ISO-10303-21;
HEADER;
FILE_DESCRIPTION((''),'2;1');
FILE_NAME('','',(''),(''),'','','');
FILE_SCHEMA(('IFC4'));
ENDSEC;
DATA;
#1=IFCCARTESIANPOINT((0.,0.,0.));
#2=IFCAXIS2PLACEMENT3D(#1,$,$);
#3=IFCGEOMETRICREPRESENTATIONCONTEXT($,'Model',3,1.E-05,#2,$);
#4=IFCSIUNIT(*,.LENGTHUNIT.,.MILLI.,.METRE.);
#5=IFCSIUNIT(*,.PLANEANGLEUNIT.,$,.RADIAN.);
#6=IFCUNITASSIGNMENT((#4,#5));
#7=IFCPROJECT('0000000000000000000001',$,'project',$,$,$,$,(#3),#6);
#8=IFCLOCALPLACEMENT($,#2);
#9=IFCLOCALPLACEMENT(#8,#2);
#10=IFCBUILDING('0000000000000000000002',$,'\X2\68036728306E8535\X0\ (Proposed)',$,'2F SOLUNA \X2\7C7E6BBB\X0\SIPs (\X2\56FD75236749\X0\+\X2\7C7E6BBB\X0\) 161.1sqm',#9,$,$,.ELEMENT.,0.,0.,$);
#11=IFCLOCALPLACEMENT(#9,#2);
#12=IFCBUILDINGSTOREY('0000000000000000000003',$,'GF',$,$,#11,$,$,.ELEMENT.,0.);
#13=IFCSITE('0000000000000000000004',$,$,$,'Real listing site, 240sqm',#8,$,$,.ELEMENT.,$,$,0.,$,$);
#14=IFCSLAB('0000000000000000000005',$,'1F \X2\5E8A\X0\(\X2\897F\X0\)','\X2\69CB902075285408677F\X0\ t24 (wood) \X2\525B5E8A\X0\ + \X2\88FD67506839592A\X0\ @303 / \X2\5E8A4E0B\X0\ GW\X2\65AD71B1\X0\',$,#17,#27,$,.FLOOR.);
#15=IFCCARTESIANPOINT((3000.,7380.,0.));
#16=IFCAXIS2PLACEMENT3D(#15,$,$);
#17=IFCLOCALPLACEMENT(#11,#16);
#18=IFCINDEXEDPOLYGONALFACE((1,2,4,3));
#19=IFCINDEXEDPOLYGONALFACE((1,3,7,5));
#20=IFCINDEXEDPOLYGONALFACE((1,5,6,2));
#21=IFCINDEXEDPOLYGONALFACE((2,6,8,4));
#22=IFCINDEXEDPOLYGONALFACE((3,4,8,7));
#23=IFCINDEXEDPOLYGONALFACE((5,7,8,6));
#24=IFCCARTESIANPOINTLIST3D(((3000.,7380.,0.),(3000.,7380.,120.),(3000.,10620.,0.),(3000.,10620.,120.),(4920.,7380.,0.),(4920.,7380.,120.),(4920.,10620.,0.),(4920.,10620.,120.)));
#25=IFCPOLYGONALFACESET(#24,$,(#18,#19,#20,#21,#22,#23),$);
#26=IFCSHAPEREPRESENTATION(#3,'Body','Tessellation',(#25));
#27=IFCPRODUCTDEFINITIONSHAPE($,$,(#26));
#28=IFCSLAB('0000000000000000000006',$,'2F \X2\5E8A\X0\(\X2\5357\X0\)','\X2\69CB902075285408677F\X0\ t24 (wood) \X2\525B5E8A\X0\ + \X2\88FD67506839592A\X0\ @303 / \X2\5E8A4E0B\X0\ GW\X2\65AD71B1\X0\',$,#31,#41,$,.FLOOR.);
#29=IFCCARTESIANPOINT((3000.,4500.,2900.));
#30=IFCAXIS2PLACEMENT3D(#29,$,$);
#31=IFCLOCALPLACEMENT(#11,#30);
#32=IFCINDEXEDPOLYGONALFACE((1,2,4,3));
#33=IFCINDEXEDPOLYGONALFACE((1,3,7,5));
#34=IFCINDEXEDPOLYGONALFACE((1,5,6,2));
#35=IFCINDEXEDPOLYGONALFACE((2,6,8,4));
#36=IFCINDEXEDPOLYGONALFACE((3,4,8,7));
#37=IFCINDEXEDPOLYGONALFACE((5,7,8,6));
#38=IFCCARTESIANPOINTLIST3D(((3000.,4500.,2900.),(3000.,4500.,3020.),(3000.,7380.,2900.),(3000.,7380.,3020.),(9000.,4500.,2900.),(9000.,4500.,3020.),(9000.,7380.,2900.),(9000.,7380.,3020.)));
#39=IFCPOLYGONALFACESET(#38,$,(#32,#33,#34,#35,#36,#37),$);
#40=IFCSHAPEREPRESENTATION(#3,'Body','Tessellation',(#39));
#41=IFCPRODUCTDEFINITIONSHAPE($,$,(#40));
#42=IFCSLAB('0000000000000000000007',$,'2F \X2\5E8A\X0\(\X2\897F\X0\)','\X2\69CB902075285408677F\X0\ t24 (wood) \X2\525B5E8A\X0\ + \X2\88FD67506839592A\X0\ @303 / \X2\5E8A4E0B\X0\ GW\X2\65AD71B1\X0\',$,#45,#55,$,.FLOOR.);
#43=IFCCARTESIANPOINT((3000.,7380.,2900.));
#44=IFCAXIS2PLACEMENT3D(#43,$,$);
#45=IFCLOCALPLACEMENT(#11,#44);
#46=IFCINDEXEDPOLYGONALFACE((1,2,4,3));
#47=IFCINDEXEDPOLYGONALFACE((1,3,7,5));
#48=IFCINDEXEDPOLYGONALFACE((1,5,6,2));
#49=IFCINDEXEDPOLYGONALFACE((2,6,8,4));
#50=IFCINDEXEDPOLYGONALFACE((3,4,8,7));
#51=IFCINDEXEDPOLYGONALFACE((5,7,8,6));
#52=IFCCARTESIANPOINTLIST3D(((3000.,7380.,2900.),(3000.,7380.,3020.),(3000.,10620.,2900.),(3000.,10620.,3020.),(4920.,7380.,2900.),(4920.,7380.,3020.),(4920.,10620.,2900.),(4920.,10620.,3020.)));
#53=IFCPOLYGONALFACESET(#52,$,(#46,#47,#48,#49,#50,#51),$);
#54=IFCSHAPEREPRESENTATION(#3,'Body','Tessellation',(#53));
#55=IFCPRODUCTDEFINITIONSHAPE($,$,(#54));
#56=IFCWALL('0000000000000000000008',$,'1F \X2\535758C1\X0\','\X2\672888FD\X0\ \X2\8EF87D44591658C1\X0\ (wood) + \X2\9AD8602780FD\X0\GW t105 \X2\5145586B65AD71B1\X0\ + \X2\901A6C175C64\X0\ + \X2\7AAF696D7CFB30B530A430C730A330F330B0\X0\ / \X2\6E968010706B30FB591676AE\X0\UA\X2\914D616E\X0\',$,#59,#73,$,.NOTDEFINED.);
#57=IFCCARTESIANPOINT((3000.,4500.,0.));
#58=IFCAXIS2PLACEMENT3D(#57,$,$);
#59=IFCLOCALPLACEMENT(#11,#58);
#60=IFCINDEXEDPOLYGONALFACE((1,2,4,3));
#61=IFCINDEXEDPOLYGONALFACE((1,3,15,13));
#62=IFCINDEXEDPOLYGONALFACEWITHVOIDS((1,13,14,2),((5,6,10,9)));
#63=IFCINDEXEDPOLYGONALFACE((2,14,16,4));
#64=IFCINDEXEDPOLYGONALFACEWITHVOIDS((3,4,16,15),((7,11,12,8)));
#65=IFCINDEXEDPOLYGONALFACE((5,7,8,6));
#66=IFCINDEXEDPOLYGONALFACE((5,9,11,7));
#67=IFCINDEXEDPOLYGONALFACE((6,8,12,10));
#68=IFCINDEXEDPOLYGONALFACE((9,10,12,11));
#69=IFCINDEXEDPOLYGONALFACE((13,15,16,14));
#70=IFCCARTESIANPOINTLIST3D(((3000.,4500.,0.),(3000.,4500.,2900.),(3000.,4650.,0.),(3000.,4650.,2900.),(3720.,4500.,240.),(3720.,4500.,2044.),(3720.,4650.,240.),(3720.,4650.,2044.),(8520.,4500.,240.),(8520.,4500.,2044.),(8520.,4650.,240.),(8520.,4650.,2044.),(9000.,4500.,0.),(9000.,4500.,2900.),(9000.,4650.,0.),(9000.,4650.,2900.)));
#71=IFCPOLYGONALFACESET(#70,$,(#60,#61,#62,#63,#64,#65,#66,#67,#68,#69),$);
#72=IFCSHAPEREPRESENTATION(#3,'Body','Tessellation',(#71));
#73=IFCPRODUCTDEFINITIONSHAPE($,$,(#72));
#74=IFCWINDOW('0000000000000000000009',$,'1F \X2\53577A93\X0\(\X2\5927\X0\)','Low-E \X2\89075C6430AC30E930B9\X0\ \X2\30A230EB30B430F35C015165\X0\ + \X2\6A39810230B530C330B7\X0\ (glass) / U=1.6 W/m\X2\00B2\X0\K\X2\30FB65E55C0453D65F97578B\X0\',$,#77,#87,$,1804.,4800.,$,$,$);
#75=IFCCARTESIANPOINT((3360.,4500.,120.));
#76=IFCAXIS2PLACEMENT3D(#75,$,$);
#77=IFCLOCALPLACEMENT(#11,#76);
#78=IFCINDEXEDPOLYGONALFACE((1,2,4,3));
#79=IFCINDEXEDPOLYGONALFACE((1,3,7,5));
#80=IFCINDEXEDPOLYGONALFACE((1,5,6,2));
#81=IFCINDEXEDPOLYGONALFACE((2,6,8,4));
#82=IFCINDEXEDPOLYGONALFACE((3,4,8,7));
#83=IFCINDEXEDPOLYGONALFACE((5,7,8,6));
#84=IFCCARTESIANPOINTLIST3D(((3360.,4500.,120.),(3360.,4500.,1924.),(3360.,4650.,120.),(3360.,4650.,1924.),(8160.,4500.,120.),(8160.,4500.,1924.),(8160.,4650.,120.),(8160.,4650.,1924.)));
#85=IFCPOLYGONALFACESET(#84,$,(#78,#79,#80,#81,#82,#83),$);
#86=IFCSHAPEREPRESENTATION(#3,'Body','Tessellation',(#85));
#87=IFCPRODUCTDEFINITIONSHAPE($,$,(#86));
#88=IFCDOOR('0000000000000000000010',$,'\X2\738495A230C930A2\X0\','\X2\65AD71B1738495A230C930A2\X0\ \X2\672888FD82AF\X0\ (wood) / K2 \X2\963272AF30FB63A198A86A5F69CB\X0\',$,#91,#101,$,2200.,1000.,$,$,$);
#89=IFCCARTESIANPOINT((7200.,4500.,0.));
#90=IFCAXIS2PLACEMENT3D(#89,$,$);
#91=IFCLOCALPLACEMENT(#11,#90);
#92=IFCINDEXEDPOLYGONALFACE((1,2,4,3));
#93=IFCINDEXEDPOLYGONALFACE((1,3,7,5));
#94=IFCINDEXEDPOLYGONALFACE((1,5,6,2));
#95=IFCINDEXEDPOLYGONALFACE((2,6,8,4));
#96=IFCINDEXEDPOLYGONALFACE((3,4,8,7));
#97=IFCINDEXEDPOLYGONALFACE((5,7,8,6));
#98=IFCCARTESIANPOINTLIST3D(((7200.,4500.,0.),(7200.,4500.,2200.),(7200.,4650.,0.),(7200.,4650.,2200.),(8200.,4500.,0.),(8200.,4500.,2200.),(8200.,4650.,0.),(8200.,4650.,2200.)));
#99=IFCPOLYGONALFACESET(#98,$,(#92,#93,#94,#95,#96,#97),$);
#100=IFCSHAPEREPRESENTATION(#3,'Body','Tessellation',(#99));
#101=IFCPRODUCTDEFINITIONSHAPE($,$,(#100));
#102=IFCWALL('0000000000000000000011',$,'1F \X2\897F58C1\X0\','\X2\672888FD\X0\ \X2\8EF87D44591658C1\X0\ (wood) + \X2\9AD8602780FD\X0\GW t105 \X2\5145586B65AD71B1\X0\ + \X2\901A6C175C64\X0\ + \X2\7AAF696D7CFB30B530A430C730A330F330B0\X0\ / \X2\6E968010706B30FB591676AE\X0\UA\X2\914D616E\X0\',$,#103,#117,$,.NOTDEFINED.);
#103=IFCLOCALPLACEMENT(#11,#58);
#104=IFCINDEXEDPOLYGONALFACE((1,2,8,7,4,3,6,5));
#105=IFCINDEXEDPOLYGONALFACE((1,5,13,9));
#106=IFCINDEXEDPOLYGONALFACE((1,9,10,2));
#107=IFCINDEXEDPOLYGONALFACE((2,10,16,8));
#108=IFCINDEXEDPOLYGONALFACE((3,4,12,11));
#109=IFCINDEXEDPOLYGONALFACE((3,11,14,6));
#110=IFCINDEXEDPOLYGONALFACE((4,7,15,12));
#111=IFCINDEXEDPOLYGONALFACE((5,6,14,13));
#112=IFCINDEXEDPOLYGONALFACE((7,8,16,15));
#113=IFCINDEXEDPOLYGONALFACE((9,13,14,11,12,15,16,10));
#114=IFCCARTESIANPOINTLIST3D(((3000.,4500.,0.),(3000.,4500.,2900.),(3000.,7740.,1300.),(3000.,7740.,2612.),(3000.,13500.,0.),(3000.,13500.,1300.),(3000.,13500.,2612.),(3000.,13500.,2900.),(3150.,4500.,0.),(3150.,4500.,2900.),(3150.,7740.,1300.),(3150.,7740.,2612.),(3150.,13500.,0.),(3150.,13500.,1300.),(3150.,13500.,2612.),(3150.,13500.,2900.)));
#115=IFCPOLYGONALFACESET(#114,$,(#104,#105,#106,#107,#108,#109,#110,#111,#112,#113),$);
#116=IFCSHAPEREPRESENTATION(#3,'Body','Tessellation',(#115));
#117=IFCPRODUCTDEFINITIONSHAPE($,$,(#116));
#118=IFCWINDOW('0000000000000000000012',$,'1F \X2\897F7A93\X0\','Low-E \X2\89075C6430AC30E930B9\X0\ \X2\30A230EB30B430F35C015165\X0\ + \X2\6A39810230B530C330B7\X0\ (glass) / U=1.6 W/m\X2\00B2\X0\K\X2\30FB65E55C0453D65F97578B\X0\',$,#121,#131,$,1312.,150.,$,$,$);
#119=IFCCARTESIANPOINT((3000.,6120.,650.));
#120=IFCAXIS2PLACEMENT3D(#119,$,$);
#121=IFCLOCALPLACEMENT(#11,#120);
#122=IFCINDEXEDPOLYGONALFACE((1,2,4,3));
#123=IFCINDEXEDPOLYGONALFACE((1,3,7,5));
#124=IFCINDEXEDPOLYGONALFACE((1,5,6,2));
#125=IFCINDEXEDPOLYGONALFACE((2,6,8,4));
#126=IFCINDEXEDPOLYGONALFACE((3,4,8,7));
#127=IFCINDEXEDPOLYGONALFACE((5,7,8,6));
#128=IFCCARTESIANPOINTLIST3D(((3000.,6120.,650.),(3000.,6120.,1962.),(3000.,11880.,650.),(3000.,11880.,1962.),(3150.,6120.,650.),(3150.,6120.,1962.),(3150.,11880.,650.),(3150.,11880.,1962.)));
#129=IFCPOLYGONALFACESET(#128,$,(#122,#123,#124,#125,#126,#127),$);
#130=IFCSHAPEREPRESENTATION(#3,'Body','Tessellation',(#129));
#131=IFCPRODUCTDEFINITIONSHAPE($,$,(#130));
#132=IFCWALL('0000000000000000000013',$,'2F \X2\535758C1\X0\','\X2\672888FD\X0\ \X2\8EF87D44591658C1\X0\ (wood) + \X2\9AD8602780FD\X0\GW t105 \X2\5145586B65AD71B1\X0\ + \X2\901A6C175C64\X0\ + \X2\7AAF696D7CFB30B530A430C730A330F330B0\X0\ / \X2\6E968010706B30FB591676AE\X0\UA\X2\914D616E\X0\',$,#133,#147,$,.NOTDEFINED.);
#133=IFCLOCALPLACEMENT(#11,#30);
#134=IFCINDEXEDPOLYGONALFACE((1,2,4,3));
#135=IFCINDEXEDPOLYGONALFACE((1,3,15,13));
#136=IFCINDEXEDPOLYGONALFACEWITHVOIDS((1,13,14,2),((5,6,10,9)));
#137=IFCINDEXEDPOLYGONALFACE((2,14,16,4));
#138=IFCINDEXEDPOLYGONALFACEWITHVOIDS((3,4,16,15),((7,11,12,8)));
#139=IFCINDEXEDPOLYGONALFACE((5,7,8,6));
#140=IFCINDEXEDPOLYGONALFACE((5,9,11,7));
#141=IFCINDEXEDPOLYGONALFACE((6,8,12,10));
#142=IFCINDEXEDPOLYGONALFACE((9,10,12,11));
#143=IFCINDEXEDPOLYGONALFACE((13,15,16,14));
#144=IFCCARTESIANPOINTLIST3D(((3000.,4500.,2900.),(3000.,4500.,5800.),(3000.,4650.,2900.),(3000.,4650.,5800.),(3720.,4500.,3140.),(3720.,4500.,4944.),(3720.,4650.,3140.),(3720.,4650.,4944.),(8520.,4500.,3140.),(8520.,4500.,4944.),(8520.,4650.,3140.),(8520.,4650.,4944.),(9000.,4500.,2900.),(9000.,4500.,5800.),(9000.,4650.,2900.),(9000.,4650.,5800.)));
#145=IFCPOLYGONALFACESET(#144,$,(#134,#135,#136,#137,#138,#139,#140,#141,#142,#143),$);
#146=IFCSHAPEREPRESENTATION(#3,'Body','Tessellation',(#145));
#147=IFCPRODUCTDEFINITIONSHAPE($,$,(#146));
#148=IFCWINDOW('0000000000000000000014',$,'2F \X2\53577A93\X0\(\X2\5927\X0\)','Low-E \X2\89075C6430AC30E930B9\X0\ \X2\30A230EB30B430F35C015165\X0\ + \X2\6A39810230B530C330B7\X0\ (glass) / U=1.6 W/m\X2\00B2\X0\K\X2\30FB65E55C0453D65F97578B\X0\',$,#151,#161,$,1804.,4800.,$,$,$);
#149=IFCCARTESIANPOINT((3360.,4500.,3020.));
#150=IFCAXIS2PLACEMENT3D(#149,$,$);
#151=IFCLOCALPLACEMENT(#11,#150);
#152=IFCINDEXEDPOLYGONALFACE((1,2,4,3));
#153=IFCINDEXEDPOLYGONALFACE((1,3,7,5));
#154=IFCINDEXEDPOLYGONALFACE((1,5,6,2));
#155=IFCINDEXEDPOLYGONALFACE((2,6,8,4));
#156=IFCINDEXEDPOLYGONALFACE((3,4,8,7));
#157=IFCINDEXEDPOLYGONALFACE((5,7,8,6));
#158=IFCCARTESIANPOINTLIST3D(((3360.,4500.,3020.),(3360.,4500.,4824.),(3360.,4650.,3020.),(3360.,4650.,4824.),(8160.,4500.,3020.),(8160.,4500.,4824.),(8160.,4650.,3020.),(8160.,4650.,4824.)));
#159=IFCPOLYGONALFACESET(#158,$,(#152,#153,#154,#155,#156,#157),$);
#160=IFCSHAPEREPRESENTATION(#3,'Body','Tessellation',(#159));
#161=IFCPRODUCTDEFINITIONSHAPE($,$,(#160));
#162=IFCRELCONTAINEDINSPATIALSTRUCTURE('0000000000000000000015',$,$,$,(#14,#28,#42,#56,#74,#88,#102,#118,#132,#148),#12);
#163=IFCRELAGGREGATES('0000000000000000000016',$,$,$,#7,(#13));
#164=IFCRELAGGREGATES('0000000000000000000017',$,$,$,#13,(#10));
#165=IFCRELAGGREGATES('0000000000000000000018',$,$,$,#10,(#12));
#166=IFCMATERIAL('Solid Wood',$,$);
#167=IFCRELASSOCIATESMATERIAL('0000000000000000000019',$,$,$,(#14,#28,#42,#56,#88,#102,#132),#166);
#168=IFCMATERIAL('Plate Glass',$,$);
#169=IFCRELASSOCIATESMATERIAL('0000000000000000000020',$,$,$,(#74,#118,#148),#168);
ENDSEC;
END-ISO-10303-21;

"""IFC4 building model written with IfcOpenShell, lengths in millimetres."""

from ifc_helpers import new_model, si_unit, frame, frame_2d, origin, place, context, project, spatial, rectangle, extrude, material, element, fill, save


model = new_model("IFC4")

# Units and contexts
model_context = context("Model", 3, precision=1e-05, world=origin())
ifc_project = project(units=[si_unit("LENGTHUNIT", "METRE", prefix="MILLI"), si_unit("PLANEANGLEUNIT", "RADIAN")], contexts=[model_context])

# Site, building, storey
site_placement = place(None, origin())
site = spatial("IfcSite", under=ifc_project, at=site_placement, ObjectType="Real listing site, 240sqm", CompositionType="ELEMENT", RefElevation=0.0)
building_placement = place(site_placement, origin())
building = spatial("IfcBuilding", under=site, at=building_placement, Name="栃木の蔵 (Proposed)", ObjectType="2F SOLUNA 籾殻SIPs (国産杉+籾殻) 161.1sqm", CompositionType="ELEMENT", ElevationOfRefHeight=0.0, ElevationOfTerrain=0.0)
storey_placement = place(building_placement, origin())
storey = spatial("IfcBuildingStorey", under=building, at=storey_placement, Name="GF", CompositionType="ELEMENT", Elevation=0.0)

# Slabs
ifc_material_1 = material(Name="Solid Wood")
slab_1_placement = place(storey_placement, frame((3000.0, 7380.0, 0.0)))
element("IfcSlab", 1, at=slab_1_placement, inside=storey, material=ifc_material_1, Name="1F 床(西)", Description="構造用合板 t24 (wood) 剛床 + 製材根太 @303 / 床下 GW断熱", PredefinedType="FLOOR", context=model_context, shape_type="SweptSolid", body=[
    extrude(rectangle(XDim=1920.0, YDim=3240.0, at=frame_2d((960.0, 1620.0))), frame((3000.0, 7380.0, 0.0)), (0.0, 0.0, 1.0), 120.0),
])
slab_2_placement = place(storey_placement, frame((3000.0, 4500.0, 2900.0)))
element("IfcSlab", 2, at=slab_2_placement, inside=storey, material=ifc_material_1, Name="2F 床(南)", Description="構造用合板 t24 (wood) 剛床 + 製材根太 @303 / 床下 GW断熱", PredefinedType="FLOOR", context=model_context, shape_type="SweptSolid", body=[
    extrude(rectangle(XDim=6000.0, YDim=2880.0, at=frame_2d((3000.0, 1440.0))), frame((3000.0, 4500.0, 2900.0)), (0.0, 0.0, 1.0), 120.0),
])
slab_3_placement = place(storey_placement, frame((3000.0, 7380.0, 2900.0)))
element("IfcSlab", 3, at=slab_3_placement, inside=storey, material=ifc_material_1, Name="2F 床(西)", Description="構造用合板 t24 (wood) 剛床 + 製材根太 @303 / 床下 GW断熱", PredefinedType="FLOOR", context=model_context, shape_type="SweptSolid", body=[
    extrude(rectangle(XDim=1920.0, YDim=3240.0, at=frame_2d((960.0, 1620.0))), frame((3000.0, 7380.0, 2900.0)), (0.0, 0.0, 1.0), 120.0),
])

# Wall, openings, window, door
wall_1_placement = place(storey_placement, frame((3000.0, 4500.0, 0.0)))
wall_1 = element("IfcWall", 4, at=wall_1_placement, inside=storey, material=ifc_material_1, Name="1F 南壁", Description="木製 軸組外壁 (wood) + 高性能GW t105 充填断熱 + 通気層 + 窯業系サイディング / 準耐火・外皮UA配慮", PredefinedType="NOTDEFINED", context=model_context, shape_type="SweptSolid", body=[
    extrude(rectangle(XDim=6000.0, YDim=150.0, at=frame_2d((3000.0, 75.0))), frame((3000.0, 4500.0, 0.0)), (0.0, 0.0, 1.0), 2900.0),
])
opening_1_placement = place(storey_placement, frame((3360.0, 4500.0, 120.0)))
opening_1 = element("IfcOpeningElement", 5, at=opening_1_placement, cuts=wall_1, PredefinedType="NOTDEFINED", context=model_context, shape_type="SweptSolid", body=[
    extrude(rectangle(XDim=4800.0, YDim=150.0, at=frame_2d((2400.0, 75.0))), frame((3360.0, 4500.0, 120.0)), (0.0, 0.0, 1.0), 1804.0),
])
opening_2_placement = place(storey_placement, frame((7200.0, 4500.0, 0.0)))
opening_2 = element("IfcOpeningElement", 6, at=opening_2_placement, cuts=wall_1, PredefinedType="NOTDEFINED", context=model_context, shape_type="SweptSolid", body=[
    extrude(rectangle(XDim=1000.0, YDim=150.0, at=frame_2d((500.0, 75.0))), frame((7200.0, 4500.0, 0.0)), (0.0, 0.0, 1.0), 2200.0),
])
ifc_material_2 = material(Name="Plate Glass")
window_1_placement = place(storey_placement, frame((3360.0, 4500.0, 120.0)))
window_1 = element("IfcWindow", 7, at=window_1_placement, inside=storey, material=ifc_material_2, Name="1F 南窓(大)", Description="Low-E 複層ガラス アルゴン封入 + 樹脂サッシ (glass) / U=1.6 W/m²K・日射取得型", OverallHeight=1804.0, OverallWidth=4800.0, context=model_context, shape_type="SweptSolid", body=[
    extrude(rectangle(XDim=4800.0, YDim=150.0, at=frame_2d((2400.0, 75.0))), frame((3360.0, 4500.0, 120.0)), (0.0, 0.0, 1.0), 1804.0),
])
fill(opening_1, window_1)
door_placement = place(storey_placement, frame((7200.0, 4500.0, 0.0)))
door = element("IfcDoor", 8, at=door_placement, inside=storey, material=ifc_material_1, Name="玄関ドア", Description="断熱玄関ドア 木製芯 (wood) / K2 防犯・採風機構", OverallHeight=2200.0, OverallWidth=1000.0, context=model_context, shape_type="SweptSolid", body=[
    extrude(rectangle(XDim=1000.0, YDim=150.0, at=frame_2d((500.0, 75.0))), frame((7200.0, 4500.0, 0.0)), (0.0, 0.0, 1.0), 2200.0),
])
fill(opening_2, door)

# Walls, openings, windows
wall_2_placement = place(storey_placement, frame((3000.0, 4500.0, 0.0)))
wall_2 = element("IfcWall", 9, at=wall_2_placement, inside=storey, material=ifc_material_1, Name="1F 西壁", Description="木製 軸組外壁 (wood) + 高性能GW t105 充填断熱 + 通気層 + 窯業系サイディング / 準耐火・外皮UA配慮", PredefinedType="NOTDEFINED", context=model_context, shape_type="SweptSolid", body=[
    extrude(rectangle(XDim=150.0, YDim=9000.0, at=frame_2d((75.0, 4500.0))), frame((3000.0, 4500.0, 0.0)), (0.0, 0.0, 1.0), 2900.0),
])
opening_3_placement = place(storey_placement, frame((3000.0, 6120.0, 650.0)))
opening_3 = element("IfcOpeningElement", 10, at=opening_3_placement, cuts=wall_2, PredefinedType="NOTDEFINED", context=model_context, shape_type="SweptSolid", body=[
    extrude(rectangle(XDim=150.0, YDim=5760.0, at=frame_2d((75.0, 2880.0))), frame((3000.0, 6120.0, 650.0)), (0.0, 0.0, 1.0), 1312.0),
])
window_2_placement = place(storey_placement, frame((3000.0, 6120.0, 650.0)))
window_2 = element("IfcWindow", 11, at=window_2_placement, inside=storey, material=ifc_material_2, Name="1F 西窓", Description="Low-E 複層ガラス アルゴン封入 + 樹脂サッシ (glass) / U=1.6 W/m²K・日射取得型", OverallHeight=1312.0, OverallWidth=150.0, context=model_context, shape_type="SweptSolid", body=[
    extrude(rectangle(XDim=150.0, YDim=5760.0, at=frame_2d((75.0, 2880.0))), frame((3000.0, 6120.0, 650.0)), (0.0, 0.0, 1.0), 1312.0),
])
fill(opening_3, window_2)
wall_3_placement = place(storey_placement, frame((3000.0, 4500.0, 2900.0)))
wall_3 = element("IfcWall", 12, at=wall_3_placement, inside=storey, material=ifc_material_1, Name="2F 南壁", Description="木製 軸組外壁 (wood) + 高性能GW t105 充填断熱 + 通気層 + 窯業系サイディング / 準耐火・外皮UA配慮", PredefinedType="NOTDEFINED", context=model_context, shape_type="SweptSolid", body=[
    extrude(rectangle(XDim=6000.0, YDim=150.0, at=frame_2d((3000.0, 75.0))), frame((3000.0, 4500.0, 2900.0)), (0.0, 0.0, 1.0), 2900.0),
])
opening_4_placement = place(storey_placement, frame((3360.0, 4500.0, 3020.0)))
opening_4 = element("IfcOpeningElement", 13, at=opening_4_placement, cuts=wall_3, PredefinedType="NOTDEFINED", context=model_context, shape_type="SweptSolid", body=[
    extrude(rectangle(XDim=4800.0, YDim=150.0, at=frame_2d((2400.0, 75.0))), frame((3360.0, 4500.0, 3020.0)), (0.0, 0.0, 1.0), 1804.0),
])
window_3_placement = place(storey_placement, frame((3360.0, 4500.0, 3020.0)))
window_3 = element("IfcWindow", 14, at=window_3_placement, inside=storey, material=ifc_material_2, Name="2F 南窓(大)", Description="Low-E 複層ガラス アルゴン封入 + 樹脂サッシ (glass) / U=1.6 W/m²K・日射取得型", OverallHeight=1804.0, OverallWidth=4800.0, context=model_context, shape_type="SweptSolid", body=[
    extrude(rectangle(XDim=4800.0, YDim=150.0, at=frame_2d((2400.0, 75.0))), frame((3360.0, 4500.0, 3020.0)), (0.0, 0.0, 1.0), 1804.0),
])
fill(opening_4, window_3)

save(model, "model.ifc")
